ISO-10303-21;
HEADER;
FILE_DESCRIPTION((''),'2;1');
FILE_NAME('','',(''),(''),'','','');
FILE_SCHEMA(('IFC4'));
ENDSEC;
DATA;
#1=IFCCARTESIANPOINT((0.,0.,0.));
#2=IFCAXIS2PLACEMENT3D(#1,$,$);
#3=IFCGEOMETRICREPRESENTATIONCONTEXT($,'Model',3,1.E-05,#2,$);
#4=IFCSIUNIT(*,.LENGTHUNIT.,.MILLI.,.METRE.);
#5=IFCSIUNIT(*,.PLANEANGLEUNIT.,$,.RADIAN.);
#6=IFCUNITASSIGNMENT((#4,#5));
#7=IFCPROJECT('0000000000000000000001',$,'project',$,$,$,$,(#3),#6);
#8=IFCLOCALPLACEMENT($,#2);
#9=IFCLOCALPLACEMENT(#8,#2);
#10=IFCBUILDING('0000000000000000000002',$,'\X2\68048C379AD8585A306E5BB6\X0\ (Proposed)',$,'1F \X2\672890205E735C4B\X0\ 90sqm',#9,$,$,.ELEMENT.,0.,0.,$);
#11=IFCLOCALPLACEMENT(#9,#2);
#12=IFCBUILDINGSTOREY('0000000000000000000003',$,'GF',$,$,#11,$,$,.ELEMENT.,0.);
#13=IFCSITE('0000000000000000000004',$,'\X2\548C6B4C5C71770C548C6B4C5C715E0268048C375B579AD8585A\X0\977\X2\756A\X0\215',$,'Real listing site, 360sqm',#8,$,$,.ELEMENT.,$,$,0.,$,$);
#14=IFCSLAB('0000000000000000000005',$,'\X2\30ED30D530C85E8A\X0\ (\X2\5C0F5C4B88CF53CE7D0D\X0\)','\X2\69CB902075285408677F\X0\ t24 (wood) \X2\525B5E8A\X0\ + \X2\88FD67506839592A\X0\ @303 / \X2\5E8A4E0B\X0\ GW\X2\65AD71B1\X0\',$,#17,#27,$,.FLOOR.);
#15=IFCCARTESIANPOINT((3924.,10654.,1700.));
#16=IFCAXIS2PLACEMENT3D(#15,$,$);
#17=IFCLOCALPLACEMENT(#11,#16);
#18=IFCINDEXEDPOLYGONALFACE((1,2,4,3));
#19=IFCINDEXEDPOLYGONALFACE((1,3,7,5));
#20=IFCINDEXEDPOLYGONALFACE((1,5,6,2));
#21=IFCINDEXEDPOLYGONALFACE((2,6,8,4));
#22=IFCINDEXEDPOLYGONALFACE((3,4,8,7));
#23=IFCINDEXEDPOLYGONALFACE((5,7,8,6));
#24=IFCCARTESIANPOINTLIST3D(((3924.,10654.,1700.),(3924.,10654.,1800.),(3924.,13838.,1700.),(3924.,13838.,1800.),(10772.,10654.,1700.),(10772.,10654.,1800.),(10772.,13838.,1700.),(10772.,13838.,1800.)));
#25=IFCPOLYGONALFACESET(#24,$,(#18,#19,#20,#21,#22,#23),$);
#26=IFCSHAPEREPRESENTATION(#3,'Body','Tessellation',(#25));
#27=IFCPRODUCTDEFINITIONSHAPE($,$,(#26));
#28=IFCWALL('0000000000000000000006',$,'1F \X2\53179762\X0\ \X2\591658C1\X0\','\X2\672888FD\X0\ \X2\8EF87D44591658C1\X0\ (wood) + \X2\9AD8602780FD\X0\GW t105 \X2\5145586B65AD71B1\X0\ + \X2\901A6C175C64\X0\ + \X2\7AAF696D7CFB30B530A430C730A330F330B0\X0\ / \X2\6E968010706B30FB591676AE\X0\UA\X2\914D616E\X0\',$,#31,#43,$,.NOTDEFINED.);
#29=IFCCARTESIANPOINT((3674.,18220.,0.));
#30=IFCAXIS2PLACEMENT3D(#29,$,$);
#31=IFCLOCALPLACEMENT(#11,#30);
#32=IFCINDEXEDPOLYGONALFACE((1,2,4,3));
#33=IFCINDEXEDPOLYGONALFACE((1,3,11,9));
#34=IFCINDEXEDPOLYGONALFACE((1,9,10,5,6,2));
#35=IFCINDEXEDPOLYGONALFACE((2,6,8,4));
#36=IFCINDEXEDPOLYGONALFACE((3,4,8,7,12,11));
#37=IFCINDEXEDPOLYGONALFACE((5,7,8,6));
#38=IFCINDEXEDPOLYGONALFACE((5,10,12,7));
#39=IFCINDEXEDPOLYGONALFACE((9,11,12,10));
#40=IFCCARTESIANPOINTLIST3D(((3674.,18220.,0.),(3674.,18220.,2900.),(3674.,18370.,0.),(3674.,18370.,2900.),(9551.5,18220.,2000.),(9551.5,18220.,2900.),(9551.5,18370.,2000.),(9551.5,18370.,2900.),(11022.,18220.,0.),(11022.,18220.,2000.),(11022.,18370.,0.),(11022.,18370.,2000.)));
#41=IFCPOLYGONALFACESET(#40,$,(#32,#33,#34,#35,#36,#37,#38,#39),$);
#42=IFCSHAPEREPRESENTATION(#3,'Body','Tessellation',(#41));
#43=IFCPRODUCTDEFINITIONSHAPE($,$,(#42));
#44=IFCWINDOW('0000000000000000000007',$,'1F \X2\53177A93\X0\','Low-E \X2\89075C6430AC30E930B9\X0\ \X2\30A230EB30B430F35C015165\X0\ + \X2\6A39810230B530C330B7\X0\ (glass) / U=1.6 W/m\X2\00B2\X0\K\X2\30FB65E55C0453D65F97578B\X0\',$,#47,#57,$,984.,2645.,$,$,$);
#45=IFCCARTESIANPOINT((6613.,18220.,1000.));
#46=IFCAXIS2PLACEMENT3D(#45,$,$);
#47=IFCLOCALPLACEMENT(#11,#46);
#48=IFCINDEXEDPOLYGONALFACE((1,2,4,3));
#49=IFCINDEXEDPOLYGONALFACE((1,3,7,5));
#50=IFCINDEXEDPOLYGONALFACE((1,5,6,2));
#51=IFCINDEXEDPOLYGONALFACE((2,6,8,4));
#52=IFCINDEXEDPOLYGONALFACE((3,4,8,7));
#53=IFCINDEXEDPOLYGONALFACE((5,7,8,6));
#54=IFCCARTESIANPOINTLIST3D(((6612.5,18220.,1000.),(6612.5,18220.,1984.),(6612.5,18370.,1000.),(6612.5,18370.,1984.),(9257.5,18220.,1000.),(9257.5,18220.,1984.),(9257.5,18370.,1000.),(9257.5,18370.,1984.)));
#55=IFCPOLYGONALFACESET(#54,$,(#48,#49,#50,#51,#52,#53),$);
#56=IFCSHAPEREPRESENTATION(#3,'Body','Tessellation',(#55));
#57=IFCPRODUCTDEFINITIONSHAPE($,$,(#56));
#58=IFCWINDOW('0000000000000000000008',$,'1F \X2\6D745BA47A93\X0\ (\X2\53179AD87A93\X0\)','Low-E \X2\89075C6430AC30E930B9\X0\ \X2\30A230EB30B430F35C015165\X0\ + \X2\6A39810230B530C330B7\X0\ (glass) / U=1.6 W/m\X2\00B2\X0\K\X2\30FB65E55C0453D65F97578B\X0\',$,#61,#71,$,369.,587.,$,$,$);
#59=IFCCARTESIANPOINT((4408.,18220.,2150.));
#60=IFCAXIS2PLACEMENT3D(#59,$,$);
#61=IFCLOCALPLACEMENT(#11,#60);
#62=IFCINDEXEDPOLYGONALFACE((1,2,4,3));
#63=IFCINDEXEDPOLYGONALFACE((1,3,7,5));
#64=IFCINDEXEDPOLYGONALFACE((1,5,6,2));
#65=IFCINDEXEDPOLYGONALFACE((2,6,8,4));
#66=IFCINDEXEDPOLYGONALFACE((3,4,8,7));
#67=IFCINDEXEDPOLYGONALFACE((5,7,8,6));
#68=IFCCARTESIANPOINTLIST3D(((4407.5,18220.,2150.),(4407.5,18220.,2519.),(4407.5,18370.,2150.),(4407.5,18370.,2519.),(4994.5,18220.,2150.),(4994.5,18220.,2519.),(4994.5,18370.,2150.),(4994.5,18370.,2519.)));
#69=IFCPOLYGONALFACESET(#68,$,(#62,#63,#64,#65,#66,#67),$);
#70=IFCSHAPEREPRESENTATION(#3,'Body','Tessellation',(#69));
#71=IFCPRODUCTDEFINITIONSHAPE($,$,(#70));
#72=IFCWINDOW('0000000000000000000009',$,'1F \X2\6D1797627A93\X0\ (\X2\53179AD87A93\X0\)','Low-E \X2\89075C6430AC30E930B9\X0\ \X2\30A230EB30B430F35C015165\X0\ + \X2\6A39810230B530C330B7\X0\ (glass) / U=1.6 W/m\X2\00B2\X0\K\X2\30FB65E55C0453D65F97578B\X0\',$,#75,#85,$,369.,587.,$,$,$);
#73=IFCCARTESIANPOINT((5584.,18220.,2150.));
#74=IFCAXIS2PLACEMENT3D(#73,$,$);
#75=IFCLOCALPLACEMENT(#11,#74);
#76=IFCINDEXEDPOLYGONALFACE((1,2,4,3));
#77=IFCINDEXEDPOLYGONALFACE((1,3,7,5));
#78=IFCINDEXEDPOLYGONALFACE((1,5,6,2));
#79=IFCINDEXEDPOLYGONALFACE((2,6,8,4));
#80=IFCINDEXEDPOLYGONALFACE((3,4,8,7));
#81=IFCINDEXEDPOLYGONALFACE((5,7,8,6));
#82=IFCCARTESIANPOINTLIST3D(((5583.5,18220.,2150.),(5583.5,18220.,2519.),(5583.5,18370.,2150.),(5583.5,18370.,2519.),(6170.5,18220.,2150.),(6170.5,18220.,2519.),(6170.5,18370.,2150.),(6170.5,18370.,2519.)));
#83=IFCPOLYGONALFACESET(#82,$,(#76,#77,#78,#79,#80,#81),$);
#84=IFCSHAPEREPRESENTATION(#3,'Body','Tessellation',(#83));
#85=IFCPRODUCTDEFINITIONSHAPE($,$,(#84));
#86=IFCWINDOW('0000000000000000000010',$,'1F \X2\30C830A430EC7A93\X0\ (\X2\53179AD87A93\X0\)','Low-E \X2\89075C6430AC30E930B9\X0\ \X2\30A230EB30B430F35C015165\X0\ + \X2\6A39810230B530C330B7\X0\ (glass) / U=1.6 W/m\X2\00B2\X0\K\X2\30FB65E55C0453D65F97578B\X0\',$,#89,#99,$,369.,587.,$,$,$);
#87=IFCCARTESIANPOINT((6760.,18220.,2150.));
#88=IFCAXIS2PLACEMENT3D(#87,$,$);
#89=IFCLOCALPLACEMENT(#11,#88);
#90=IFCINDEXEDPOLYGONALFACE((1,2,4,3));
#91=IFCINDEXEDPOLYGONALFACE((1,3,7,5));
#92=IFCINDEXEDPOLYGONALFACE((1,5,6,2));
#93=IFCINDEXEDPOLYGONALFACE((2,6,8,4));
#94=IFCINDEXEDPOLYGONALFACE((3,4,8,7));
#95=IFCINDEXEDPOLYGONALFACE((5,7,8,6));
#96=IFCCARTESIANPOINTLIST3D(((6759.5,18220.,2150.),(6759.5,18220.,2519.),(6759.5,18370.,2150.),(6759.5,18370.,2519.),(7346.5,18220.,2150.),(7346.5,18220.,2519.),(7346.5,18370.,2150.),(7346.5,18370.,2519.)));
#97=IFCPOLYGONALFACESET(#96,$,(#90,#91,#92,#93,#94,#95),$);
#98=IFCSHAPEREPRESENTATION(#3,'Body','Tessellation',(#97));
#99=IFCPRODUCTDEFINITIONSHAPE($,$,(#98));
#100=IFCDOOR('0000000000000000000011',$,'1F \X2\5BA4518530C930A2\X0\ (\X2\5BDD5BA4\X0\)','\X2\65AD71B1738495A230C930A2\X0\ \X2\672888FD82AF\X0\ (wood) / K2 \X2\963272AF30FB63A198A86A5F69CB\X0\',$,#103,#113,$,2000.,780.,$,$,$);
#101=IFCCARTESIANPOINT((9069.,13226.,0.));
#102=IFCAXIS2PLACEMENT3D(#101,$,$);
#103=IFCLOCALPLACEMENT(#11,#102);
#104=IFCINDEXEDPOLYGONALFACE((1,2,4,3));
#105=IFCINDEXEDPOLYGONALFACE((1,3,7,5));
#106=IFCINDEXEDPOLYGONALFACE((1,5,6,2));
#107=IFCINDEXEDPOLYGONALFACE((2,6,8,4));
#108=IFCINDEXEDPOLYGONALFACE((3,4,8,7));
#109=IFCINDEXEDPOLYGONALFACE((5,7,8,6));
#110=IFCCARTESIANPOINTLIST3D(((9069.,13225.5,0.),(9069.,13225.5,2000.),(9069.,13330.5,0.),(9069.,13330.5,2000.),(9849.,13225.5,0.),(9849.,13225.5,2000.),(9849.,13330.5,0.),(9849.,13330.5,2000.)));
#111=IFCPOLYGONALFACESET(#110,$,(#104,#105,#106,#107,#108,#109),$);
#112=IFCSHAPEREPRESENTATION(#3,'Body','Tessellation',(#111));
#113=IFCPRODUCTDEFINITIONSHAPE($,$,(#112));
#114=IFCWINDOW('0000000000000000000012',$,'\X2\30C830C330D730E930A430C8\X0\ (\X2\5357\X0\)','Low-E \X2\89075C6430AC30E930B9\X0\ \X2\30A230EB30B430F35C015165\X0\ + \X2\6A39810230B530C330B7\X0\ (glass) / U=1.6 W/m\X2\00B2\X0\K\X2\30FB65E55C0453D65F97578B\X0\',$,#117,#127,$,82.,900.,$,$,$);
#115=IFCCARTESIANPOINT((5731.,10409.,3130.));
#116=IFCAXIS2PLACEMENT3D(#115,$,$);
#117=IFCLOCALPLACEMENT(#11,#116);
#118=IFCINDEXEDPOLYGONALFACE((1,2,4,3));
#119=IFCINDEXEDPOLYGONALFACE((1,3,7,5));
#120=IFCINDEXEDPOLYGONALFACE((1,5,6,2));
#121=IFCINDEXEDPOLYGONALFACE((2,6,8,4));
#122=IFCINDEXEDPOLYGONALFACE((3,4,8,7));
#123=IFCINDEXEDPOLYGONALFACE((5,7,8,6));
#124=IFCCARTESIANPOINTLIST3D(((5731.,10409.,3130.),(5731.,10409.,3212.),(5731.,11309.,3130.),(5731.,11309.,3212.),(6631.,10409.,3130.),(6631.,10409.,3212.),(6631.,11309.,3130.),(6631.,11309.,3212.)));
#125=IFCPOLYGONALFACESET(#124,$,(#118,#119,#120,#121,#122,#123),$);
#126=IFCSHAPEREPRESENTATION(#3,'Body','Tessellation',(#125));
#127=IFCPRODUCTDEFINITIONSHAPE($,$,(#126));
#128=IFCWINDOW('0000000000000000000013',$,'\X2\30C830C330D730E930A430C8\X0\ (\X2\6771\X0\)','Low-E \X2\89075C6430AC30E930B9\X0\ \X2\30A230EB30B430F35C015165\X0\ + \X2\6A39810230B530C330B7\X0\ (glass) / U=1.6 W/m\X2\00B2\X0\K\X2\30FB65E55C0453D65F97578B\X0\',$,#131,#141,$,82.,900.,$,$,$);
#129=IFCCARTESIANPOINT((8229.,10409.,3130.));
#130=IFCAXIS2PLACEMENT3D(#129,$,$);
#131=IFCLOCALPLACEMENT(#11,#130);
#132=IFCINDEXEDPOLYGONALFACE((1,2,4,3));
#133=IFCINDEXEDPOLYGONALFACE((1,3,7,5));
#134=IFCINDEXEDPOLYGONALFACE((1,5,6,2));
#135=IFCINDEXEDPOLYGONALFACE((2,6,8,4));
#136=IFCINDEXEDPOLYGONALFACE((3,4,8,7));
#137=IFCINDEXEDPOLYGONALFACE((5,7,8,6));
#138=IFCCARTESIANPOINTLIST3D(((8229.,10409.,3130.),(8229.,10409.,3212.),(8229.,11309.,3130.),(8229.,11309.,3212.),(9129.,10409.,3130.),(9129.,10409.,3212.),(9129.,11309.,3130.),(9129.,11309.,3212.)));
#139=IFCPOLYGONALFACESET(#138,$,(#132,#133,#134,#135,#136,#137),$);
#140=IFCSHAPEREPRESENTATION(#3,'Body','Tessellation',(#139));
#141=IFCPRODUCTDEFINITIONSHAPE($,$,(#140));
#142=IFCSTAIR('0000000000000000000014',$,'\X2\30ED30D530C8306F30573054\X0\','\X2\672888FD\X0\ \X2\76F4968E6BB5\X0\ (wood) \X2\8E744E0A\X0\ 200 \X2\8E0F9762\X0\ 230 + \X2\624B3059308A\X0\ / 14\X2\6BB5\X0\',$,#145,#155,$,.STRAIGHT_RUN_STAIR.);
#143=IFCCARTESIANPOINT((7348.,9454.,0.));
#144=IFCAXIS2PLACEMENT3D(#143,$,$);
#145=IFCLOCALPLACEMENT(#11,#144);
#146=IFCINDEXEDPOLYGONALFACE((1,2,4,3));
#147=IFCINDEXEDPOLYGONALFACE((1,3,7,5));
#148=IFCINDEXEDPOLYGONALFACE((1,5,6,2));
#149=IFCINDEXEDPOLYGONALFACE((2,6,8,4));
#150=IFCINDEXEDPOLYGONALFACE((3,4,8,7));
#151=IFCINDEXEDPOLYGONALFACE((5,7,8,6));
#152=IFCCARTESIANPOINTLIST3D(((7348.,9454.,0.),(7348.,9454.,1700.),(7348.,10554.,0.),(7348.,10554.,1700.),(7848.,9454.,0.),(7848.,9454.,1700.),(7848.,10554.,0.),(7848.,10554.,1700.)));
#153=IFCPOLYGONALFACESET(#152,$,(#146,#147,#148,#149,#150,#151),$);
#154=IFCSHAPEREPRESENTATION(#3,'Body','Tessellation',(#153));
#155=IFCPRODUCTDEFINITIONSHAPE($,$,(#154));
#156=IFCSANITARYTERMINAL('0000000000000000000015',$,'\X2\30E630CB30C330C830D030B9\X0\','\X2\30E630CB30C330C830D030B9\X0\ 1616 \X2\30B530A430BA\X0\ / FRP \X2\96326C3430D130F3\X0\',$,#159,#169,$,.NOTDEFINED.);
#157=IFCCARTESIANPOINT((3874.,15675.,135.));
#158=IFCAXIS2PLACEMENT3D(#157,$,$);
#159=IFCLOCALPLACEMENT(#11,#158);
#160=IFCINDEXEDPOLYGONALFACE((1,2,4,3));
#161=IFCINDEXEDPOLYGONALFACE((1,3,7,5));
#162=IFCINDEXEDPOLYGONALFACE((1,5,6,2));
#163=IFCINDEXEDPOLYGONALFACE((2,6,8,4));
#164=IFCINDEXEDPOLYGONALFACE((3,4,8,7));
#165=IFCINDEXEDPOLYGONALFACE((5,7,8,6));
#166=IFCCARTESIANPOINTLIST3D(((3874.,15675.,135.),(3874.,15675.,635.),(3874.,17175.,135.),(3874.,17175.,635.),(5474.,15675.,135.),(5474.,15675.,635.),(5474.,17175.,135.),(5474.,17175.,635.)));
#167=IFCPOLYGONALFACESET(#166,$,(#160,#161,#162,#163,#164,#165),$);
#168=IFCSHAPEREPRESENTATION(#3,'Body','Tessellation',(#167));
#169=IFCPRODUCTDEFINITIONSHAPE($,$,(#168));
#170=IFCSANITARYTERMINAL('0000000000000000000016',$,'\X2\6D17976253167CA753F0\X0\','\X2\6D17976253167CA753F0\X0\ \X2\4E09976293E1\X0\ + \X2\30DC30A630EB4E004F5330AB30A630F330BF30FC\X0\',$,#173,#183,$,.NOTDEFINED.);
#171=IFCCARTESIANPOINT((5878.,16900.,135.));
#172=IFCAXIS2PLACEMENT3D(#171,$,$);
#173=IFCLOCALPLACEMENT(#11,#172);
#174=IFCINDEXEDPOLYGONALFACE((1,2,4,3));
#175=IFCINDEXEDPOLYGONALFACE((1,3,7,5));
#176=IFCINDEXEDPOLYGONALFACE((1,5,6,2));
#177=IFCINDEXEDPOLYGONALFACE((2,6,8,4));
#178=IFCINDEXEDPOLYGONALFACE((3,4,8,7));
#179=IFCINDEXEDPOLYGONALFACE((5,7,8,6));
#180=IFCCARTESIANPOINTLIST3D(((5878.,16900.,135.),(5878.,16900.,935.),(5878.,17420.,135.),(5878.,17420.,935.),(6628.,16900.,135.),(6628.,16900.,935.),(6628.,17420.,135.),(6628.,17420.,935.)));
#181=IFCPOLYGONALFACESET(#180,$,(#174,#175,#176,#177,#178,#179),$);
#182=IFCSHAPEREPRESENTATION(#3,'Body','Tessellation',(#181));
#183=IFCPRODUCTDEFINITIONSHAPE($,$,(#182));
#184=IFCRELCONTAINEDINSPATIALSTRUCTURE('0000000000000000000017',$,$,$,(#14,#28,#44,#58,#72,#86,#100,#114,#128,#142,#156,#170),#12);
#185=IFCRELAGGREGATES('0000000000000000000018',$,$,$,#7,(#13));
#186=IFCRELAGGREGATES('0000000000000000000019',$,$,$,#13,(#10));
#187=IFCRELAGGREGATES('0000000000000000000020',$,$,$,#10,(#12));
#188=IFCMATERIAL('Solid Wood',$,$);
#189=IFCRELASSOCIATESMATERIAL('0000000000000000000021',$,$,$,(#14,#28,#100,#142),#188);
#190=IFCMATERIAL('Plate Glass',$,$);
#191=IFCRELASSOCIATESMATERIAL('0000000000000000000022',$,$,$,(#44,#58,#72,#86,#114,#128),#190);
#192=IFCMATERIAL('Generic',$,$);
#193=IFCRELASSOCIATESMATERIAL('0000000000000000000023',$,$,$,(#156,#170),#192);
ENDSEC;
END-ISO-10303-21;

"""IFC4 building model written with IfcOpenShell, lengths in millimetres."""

from ifc_helpers import new_model, si_unit, frame, frame_2d, origin, place, context, project, spatial, rectangle, extrude, material, element, fill, save


model = new_model("IFC4")

# Units and contexts
model_context = context("Model", 3, precision=1e-05, world=origin())
ifc_project = project(units=[si_unit("LENGTHUNIT", "METRE", prefix="MILLI"), si_unit("PLANEANGLEUNIT", "RADIAN")], contexts=[model_context])

# Site, building, storey
site_placement = place(None, origin())
site = spatial("IfcSite", under=ifc_project, at=site_placement, Name="和歌山県和歌山市栄谷字高塚977番215", ObjectType="Real listing site, 360sqm", CompositionType="ELEMENT", RefElevation=0.0)
building_placement = place(site_placement, origin())
building = spatial("IfcBuilding", under=site, at=building_placement, Name="栄谷高塚の家 (Proposed)", ObjectType="1F 木造平屋 90sqm", CompositionType="ELEMENT", ElevationOfRefHeight=0.0, ElevationOfTerrain=0.0)
storey_placement = place(building_placement, origin())
storey = spatial("IfcBuildingStorey", under=building, at=storey_placement, Name="GF", CompositionType="ELEMENT", Elevation=0.0)

# Slab
ifc_material_1 = material(Name="Solid Wood")
slab_placement = place(storey_placement, frame((3924.0, 10654.0, 1700.0)))
element("IfcSlab", 1, at=slab_placement, inside=storey, material=ifc_material_1, Name="ロフト床 (小屋裏収納)", Description="構造用合板 t24 (wood) 剛床 + 製材根太 @303 / 床下 GW断熱", PredefinedType="FLOOR", context=model_context, shape_type="SweptSolid", body=[
    extrude(rectangle(XDim=6848.0, YDim=3184.0, at=frame_2d((3424.0, 1592.0))), frame((3924.0, 10654.0, 1700.0)), (0.0, 0.0, 1.0), 100.0),
])

# Wall, openings, windows
wall_1_placement = place(storey_placement, frame((3674.0, 18220.0, 0.0)))
wall_1 = element("IfcWall", 2, at=wall_1_placement, inside=storey, material=ifc_material_1, Name="1F 北面 外壁", Description="木製 軸組外壁 (wood) + 高性能GW t105 充填断熱 + 通気層 + 窯業系サイディング / 準耐火・外皮UA配慮", PredefinedType="NOTDEFINED", context=model_context, shape_type="SweptSolid", body=[
    extrude(rectangle(XDim=7348.0, YDim=150.0, at=frame_2d((3674.0, 75.0))), frame((3674.0, 18220.0, 0.0)), (0.0, 0.0, 1.0), 2900.0),
])
opening_1_placement = place(storey_placement, frame((6613.0, 18220.0, 1000.0)))
opening_1 = element("IfcOpeningElement", 3, at=opening_1_placement, cuts=wall_1, PredefinedType="NOTDEFINED", context=model_context, shape_type="SweptSolid", body=[
    extrude(rectangle(XDim=2645.0, YDim=150.0, at=frame_2d((1322.0, 75.0))), frame((6613.0, 18220.0, 1000.0)), (0.0, 0.0, 1.0), 984.0),
])
opening_2_placement = place(storey_placement, frame((4408.0, 18220.0, 2150.0)))
opening_2 = element("IfcOpeningElement", 4, at=opening_2_placement, cuts=wall_1, PredefinedType="NOTDEFINED", context=model_context, shape_type="SweptSolid", body=[
    extrude(rectangle(XDim=587.0, YDim=150.0, at=frame_2d((293.0, 75.0))), frame((4408.0, 18220.0, 2150.0)), (0.0, 0.0, 1.0), 369.0),
])
opening_3_placement = place(storey_placement, frame((5584.0, 18220.0, 2150.0)))
opening_3 = element("IfcOpeningElement", 5, at=opening_3_placement, cuts=wall_1, PredefinedType="NOTDEFINED", context=model_context, shape_type="SweptSolid", body=[
    extrude(rectangle(XDim=587.0, YDim=150.0, at=frame_2d((293.0, 75.0))), frame((5584.0, 18220.0, 2150.0)), (0.0, 0.0, 1.0), 369.0),
])
opening_4_placement = place(storey_placement, frame((6760.0, 18220.0, 2150.0)))
opening_4 = element("IfcOpeningElement", 6, at=opening_4_placement, cuts=wall_1, PredefinedType="NOTDEFINED", context=model_context, shape_type="SweptSolid", body=[
    extrude(rectangle(XDim=587.0, YDim=150.0, at=frame_2d((293.0, 75.0))), frame((6760.0, 18220.0, 2150.0)), (0.0, 0.0, 1.0), 369.0),
])
ifc_material_2 = material(Name="Plate Glass")
window_1_placement = place(storey_placement, frame((6613.0, 18220.0, 1000.0)))
window_1 = element("IfcWindow", 7, at=window_1_placement, inside=storey, material=ifc_material_2, Name="1F 北窓", Description="Low-E 複層ガラス アルゴン封入 + 樹脂サッシ (glass) / U=1.6 W/m²K・日射取得型", OverallHeight=984.0, OverallWidth=2645.0, context=model_context, shape_type="SweptSolid", body=[
    extrude(rectangle(XDim=2645.0, YDim=150.0, at=frame_2d((1322.0, 75.0))), frame((6613.0, 18220.0, 1000.0)), (0.0, 0.0, 1.0), 984.0),
])
fill(opening_1, window_1)
window_2_placement = place(storey_placement, frame((4408.0, 18220.0, 2150.0)))
window_2 = element("IfcWindow", 8, at=window_2_placement, inside=storey, material=ifc_material_2, Name="1F 浴室窓 (北高窓)", Description="Low-E 複層ガラス アルゴン封入 + 樹脂サッシ (glass) / U=1.6 W/m²K・日射取得型", OverallHeight=369.0, OverallWidth=587.0, context=model_context, shape_type="SweptSolid", body=[
    extrude(rectangle(XDim=587.0, YDim=150.0, at=frame_2d((293.0, 75.0))), frame((4408.0, 18220.0, 2150.0)), (0.0, 0.0, 1.0), 369.0),
])
fill(opening_2, window_2)
window_3_placement = place(storey_placement, frame((5584.0, 18220.0, 2150.0)))
window_3 = element("IfcWindow", 9, at=window_3_placement, inside=storey, material=ifc_material_2, Name="1F 洗面窓 (北高窓)", Description="Low-E 複層ガラス アルゴン封入 + 樹脂サッシ (glass) / U=1.6 W/m²K・日射取得型", OverallHeight=369.0, OverallWidth=587.0, context=model_context, shape_type="SweptSolid", body=[
    extrude(rectangle(XDim=587.0, YDim=150.0, at=frame_2d((293.0, 75.0))), frame((5584.0, 18220.0, 2150.0)), (0.0, 0.0, 1.0), 369.0),
])
fill(opening_3, window_3)
window_4_placement = place(storey_placement, frame((6760.0, 18220.0, 2150.0)))
window_4 = element("IfcWindow", 10, at=window_4_placement, inside=storey, material=ifc_material_2, Name="1F トイレ窓 (北高窓)", Description="Low-E 複層ガラス アルゴン封入 + 樹脂サッシ (glass) / U=1.6 W/m²K・日射取得型", OverallHeight=369.0, OverallWidth=587.0, context=model_context, shape_type="SweptSolid", body=[
    extrude(rectangle(XDim=587.0, YDim=150.0, at=frame_2d((293.0, 75.0))), frame((6760.0, 18220.0, 2150.0)), (0.0, 0.0, 1.0), 369.0),
])
fill(opening_4, window_4)

# Door
door_1_placement = place(storey_placement, frame((9069.0, 13226.0, 0.0)))
element("IfcDoor", 11, at=door_1_placement, inside=storey, material=ifc_material_1, Name="1F 室内ドア (寝室)", Description="断熱玄関ドア 木製芯 (wood) / K2 防犯・採風機構", OverallHeight=2000.0, OverallWidth=780.0, context=model_context, shape_type="SweptSolid", body=[
    extrude(rectangle(XDim=780.0, YDim=105.0, at=frame_2d((390.0, 52.0))), frame((9069.0, 13226.0, 0.0)), (0.0, 0.0, 1.0), 2000.0),
])

# Windows
window_5_placement = place(storey_placement, frame((5731.0, 10409.0, 3130.0)))
element("IfcWindow", 12, at=window_5_placement, inside=storey, material=ifc_material_2, Name="トップライト (南)", Description="Low-E 複層ガラス アルゴン封入 + 樹脂サッシ (glass) / U=1.6 W/m²K・日射取得型", OverallHeight=82.0, OverallWidth=900.0, context=model_context, shape_type="SweptSolid", body=[
    extrude(rectangle(XDim=900.0, YDim=900.0, at=frame_2d((450.0, 450.0))), frame((5731.0, 10409.0, 3130.0)), (0.0, 0.0, 1.0), 82.0),
])
window_6_placement = place(storey_placement, frame((8229.0, 10409.0, 3130.0)))
element("IfcWindow", 13, at=window_6_placement, inside=storey, material=ifc_material_2, Name="トップライト (東)", Description="Low-E 複層ガラス アルゴン封入 + 樹脂サッシ (glass) / U=1.6 W/m²K・日射取得型", OverallHeight=82.0, OverallWidth=900.0, context=model_context, shape_type="SweptSolid", body=[
    extrude(rectangle(XDim=900.0, YDim=900.0, at=frame_2d((450.0, 450.0))), frame((8229.0, 10409.0, 3130.0)), (0.0, 0.0, 1.0), 82.0),
])

# Stair
stair_placement = place(storey_placement, frame((7348.0, 9454.0, 0.0)))
element("IfcStair", 14, at=stair_placement, inside=storey, material=ifc_material_1, Name="ロフトはしご", Description="木製 直階段 (wood) 蹴上 200 踏面 230 + 手すり / 14段", PredefinedType="STRAIGHT_RUN_STAIR", context=model_context, shape_type="SweptSolid", body=[
    extrude(rectangle(XDim=500.0, YDim=1100.0, at=frame_2d((250.0, 550.0))), frame((7348.0, 9454.0, 0.0)), (0.0, 0.0, 1.0), 1700.0),
])

# Sanitary terminals
ifc_material_3 = material(Name="Generic")
sanitary_terminal_1_placement = place(storey_placement, frame((3874.0, 15675.0, 135.0)))
element("IfcSanitaryTerminal", 15, at=sanitary_terminal_1_placement, inside=storey, material=ifc_material_3, Name="ユニットバス", Description="ユニットバス 1616 サイズ / FRP 防水パン", PredefinedType="NOTDEFINED", context=model_context, shape_type="SweptSolid", body=[
    extrude(rectangle(XDim=1600.0, YDim=1500.0, at=frame_2d((800.0, 750.0))), frame((3874.0, 15675.0, 135.0)), (0.0, 0.0, 1.0), 500.0),
])
sanitary_terminal_2_placement = place(storey_placement, frame((5878.0, 16900.0, 135.0)))
element("IfcSanitaryTerminal", 16, at=sanitary_terminal_2_placement, inside=storey, material=ifc_material_3, Name="洗面化粧台", Description="洗面化粧台 三面鏡 + ボウル一体カウンター", PredefinedType="NOTDEFINED", context=model_context, shape_type="SweptSolid", body=[
    extrude(rectangle(XDim=750.0, YDim=520.0, at=frame_2d((375.0, 260.0))), frame((5878.0, 16900.0, 135.0)), (0.0, 0.0, 1.0), 800.0),
])

save(model, "model.ifc")
